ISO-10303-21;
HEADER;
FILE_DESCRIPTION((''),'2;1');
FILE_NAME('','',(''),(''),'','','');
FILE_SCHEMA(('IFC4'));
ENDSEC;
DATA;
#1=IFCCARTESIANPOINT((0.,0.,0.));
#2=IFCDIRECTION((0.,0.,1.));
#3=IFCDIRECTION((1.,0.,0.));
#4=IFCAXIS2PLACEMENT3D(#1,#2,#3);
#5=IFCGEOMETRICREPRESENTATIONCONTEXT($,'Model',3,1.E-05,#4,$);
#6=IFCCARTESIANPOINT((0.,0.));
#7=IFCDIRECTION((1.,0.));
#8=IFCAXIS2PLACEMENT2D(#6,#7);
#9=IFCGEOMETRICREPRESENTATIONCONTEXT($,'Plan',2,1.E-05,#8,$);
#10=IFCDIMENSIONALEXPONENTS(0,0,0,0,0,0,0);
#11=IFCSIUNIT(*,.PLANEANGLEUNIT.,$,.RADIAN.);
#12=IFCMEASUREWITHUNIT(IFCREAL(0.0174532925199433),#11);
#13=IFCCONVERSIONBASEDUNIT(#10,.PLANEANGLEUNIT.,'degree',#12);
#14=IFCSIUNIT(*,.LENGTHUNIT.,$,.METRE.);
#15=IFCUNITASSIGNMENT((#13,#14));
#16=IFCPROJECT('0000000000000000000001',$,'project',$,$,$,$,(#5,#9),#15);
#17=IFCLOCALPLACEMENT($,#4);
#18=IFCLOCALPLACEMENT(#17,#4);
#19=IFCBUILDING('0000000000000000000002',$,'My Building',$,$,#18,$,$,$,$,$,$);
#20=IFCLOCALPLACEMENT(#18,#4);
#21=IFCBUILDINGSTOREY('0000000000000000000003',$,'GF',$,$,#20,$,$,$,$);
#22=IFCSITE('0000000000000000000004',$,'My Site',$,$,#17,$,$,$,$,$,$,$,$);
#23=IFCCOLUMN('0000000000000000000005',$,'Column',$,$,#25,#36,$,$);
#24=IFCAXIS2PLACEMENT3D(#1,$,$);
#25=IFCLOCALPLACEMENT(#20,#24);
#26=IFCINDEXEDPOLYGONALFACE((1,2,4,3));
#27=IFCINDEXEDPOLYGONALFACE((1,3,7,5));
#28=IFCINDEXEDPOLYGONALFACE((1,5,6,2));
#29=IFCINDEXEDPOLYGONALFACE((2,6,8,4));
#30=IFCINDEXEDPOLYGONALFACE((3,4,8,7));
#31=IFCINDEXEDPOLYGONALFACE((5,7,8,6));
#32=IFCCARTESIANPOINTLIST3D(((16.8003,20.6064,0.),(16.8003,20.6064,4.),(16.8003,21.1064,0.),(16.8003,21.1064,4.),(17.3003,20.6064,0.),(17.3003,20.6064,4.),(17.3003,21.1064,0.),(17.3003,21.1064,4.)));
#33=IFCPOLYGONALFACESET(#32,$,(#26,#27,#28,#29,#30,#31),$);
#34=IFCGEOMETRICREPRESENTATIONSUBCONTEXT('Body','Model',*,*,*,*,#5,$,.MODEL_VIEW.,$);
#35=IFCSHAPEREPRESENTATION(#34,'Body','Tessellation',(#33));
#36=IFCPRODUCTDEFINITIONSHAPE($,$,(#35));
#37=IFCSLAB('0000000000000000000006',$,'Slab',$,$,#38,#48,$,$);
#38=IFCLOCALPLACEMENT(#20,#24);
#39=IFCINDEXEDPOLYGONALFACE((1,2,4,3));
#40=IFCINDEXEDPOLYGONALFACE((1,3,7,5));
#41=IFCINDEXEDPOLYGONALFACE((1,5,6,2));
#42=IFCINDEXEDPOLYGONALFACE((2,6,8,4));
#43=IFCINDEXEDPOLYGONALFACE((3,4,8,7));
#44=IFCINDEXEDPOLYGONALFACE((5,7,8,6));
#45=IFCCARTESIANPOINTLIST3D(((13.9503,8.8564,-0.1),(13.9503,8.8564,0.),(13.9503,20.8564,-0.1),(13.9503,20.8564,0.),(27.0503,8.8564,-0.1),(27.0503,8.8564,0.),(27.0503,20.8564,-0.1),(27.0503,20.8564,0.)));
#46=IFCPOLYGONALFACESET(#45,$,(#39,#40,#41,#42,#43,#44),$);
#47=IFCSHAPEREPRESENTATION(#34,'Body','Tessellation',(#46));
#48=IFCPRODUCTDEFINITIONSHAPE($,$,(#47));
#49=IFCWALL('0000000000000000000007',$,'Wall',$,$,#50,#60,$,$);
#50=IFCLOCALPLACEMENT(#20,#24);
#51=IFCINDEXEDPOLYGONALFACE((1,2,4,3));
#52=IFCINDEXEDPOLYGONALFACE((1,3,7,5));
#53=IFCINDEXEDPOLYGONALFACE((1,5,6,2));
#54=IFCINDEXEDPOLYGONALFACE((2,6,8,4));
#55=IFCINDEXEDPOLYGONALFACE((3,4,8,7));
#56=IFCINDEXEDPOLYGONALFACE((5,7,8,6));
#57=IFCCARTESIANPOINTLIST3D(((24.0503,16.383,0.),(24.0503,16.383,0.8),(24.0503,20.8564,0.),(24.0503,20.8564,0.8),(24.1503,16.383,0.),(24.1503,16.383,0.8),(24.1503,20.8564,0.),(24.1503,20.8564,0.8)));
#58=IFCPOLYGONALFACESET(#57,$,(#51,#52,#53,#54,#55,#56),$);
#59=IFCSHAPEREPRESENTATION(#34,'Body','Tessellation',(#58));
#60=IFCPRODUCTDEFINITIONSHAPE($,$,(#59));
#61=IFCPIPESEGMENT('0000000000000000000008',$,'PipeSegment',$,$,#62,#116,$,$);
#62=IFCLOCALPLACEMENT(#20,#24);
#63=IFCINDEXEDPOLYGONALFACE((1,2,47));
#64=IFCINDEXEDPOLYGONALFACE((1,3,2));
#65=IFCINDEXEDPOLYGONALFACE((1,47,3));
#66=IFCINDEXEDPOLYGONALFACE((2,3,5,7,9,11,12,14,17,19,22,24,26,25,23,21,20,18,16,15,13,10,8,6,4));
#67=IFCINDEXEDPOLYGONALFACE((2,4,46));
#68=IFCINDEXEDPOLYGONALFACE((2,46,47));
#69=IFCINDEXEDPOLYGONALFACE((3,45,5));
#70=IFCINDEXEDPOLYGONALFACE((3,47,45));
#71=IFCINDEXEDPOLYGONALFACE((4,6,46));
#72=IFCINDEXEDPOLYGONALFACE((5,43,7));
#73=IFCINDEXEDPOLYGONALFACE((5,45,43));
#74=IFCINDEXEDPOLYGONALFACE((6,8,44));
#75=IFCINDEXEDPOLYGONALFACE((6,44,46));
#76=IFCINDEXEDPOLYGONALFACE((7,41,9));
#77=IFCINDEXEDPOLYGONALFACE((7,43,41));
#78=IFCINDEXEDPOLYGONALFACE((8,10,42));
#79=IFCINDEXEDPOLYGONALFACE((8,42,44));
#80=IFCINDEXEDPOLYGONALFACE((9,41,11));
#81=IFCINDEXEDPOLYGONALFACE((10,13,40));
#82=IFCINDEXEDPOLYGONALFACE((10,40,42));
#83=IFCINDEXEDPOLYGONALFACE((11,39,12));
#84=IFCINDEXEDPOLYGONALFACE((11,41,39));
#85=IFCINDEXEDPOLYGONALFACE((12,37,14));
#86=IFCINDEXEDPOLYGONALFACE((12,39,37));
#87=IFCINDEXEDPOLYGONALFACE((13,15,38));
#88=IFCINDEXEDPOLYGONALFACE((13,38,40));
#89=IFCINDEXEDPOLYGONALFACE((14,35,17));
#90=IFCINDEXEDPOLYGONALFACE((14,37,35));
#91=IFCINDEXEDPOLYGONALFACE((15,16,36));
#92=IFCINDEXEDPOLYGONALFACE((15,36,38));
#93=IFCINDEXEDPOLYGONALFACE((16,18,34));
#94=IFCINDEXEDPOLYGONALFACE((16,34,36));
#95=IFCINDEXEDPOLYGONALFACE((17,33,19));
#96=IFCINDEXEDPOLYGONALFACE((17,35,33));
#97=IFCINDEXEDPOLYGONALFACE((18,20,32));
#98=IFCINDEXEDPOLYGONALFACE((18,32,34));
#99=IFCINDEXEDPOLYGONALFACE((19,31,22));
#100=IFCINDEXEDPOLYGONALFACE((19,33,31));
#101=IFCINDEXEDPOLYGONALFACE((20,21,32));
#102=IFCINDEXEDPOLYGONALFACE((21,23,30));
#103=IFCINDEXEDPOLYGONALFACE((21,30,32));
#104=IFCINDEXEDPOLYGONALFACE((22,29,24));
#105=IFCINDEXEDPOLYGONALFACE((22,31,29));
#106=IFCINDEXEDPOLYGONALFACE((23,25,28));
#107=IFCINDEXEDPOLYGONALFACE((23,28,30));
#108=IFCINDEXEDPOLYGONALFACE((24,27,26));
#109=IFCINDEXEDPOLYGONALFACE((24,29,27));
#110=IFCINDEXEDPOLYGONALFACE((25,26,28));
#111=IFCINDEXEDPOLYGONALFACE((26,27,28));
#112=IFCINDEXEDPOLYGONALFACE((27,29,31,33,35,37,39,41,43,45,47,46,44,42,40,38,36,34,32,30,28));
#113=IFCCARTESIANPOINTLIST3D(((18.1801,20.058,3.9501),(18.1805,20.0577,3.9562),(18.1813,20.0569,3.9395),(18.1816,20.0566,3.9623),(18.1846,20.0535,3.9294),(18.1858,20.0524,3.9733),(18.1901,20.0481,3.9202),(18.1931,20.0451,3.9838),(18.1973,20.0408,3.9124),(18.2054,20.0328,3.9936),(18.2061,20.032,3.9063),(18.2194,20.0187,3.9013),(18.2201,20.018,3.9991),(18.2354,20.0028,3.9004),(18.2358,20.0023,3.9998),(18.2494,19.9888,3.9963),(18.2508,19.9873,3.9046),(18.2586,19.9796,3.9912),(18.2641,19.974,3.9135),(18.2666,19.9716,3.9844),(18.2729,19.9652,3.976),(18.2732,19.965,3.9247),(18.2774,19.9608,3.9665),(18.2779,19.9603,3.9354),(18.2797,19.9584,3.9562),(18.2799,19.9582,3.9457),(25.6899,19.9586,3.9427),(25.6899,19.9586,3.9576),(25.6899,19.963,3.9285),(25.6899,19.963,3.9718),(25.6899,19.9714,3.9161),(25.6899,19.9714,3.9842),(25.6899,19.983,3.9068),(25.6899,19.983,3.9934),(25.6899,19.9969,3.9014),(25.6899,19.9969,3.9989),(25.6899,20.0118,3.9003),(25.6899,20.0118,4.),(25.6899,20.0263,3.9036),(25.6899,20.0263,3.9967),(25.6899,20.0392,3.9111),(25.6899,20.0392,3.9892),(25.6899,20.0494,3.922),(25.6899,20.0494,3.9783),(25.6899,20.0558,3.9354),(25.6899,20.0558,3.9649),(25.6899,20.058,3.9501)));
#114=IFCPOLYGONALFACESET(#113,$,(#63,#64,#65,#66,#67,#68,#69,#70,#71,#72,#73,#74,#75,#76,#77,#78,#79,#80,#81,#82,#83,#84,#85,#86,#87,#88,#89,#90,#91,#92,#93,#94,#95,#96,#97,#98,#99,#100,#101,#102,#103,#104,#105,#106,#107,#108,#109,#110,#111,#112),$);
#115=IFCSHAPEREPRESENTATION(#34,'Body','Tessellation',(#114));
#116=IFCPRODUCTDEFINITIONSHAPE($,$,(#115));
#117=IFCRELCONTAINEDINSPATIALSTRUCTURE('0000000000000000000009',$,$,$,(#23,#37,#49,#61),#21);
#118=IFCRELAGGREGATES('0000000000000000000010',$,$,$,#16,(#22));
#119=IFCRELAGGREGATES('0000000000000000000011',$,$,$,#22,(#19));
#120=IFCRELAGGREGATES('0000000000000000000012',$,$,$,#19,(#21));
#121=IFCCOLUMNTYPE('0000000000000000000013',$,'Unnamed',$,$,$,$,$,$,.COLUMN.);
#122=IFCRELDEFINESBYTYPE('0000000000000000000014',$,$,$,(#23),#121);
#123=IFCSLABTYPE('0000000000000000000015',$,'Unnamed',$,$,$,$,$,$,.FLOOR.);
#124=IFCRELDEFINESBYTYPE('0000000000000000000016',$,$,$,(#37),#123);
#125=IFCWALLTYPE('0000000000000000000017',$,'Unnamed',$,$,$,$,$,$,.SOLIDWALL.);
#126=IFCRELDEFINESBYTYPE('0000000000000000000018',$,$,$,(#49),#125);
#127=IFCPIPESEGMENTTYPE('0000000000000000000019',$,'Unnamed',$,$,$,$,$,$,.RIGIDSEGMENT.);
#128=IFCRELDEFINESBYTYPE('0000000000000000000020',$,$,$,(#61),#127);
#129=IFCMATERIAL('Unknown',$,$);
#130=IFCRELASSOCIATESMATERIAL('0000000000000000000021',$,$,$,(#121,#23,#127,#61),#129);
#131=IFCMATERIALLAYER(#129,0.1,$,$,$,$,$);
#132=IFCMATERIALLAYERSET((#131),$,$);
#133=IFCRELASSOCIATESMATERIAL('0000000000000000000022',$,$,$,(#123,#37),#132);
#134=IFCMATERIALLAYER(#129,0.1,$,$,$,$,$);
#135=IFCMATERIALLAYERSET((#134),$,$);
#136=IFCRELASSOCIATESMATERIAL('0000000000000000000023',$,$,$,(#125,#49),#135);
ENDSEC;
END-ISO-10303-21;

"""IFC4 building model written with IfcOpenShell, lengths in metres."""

from ifc_helpers import new_model, entity, si_unit, converted_unit, frame, origin_with_axes, origin_2d_with_axis, place, context, subcontext, project, spatial, line, indexed_curve, rectangle, circle, outline, extrude, clip, halfspace, material, layer, layer_set, layer_usage, material_profile, profile_set, profile_usage, type_object, element, save


model = new_model("IFC4")

# Units and contexts
model_context = context("Model", 3, precision=1e-05, world=origin_with_axes())
plan_context = context("Plan", 2, precision=1e-05, world=origin_2d_with_axis())
body_context_1 = subcontext(model_context, "Body", "Model", "MODEL_VIEW")
ifc_project = project(units=[converted_unit("PLANEANGLEUNIT", "degree", entity("IfcReal", 0.0174532925199433), si_unit("PLANEANGLEUNIT", "RADIAN"), dimensions=[0, 0, 0, 0, 0, 0, 0]), si_unit("LENGTHUNIT", "METRE")], contexts=[model_context, plan_context])

# Site, building, storey
site_placement = place(None, origin_with_axes())
site = spatial("IfcSite", under=ifc_project, at=site_placement, Name="My Site")
building_placement = place(site_placement, origin_with_axes())
building = spatial("IfcBuilding", under=site, at=building_placement, Name="My Building")
storey_placement = place(building_placement, origin_with_axes())
storey = spatial("IfcBuildingStorey", under=building, at=storey_placement, Name="GF")

# Column
ifc_material = material(Name="Unknown")
ifc_material_profile_1 = material_profile(ifc_material, rectangle(XDim=0.5, YDim=0.5))
ifc_profile_set_1 = profile_set([ifc_material_profile_1])
ifc_profile_usage_1 = profile_usage(ifc_profile_set_1, cardinal=5)
column_type = type_object("IfcColumnType", Name="Unnamed", PredefinedType="COLUMN", material=ifc_profile_set_1)
column_placement = place(storey_placement, frame((17.0503, 20.8564, 0.0), z_axis=(0.0, 0.0, 1.0), x_axis=(1.0, 0.0, 0.0)))
element("IfcColumn", 1, at=column_placement, inside=storey, type_object=column_type, material=ifc_profile_usage_1, Name="Column", context=body_context_1, shape_type="SweptSolid", body=[
    extrude(rectangle(XDim=0.5, YDim=0.5), origin_with_axes(), (0.0, 0.0, 1.0), 4.0),
])

# Slab
ifc_layer_1 = layer(ifc_material, 0.1)
ifc_layer_set_1 = layer_set([ifc_layer_1])
ifc_layer_usage_1 = layer_usage(ifc_layer_set_1, "AXIS3", "POSITIVE", -0.1)
slab_type = type_object("IfcSlabType", Name="Unnamed", PredefinedType="FLOOR", material=ifc_layer_set_1)
slab_placement = place(storey_placement, frame((13.9503, 20.8564, 0.0), z_axis=(0.0, 0.0, 1.0), x_axis=(1.0, 0.0, 0.0)))
element("IfcSlab", 2, at=slab_placement, inside=storey, type_object=slab_type, material=ifc_layer_usage_1, Name="Slab", context=body_context_1, shape_type="SweptSolid", body=[
    extrude(outline(indexed_curve([(0.0, 0.0), (13.1, 0.0), (13.1, -12.0), (0.0, -12.0), (0.0, 0.0)])), frame((0.0, 0.0, -0.1), z_axis=(0.0, 0.0, 1.0), x_axis=(1.0, 0.0, 0.0)), (0.0, 0.0, 1.0), 0.1),
])

# Shared definitions
ifc_layer_2 = layer(ifc_material, 0.1)
ifc_layer_set_2 = layer_set([ifc_layer_2])
wall_type = type_object("IfcWallType", Name="Unnamed", PredefinedType="SOLIDWALL", material=ifc_layer_set_2)

# Wall
ifc_layer_usage_2 = layer_usage(ifc_layer_set_2, "AXIS2", "POSITIVE", 0.0)
wall_1_placement = place(storey_placement, frame((24.1503, 16.383, 0.0), z_axis=(0.0, 0.0, 1.0), x_axis=(0.0, 1.0, 0.0)))
element("IfcWall", 3, at=wall_1_placement, inside=storey, type_object=wall_type, material=ifc_layer_usage_2, Name="Wall", context=body_context_1, shape_type="SweptSolid", body=[
    extrude(outline(indexed_curve([(0.0, 0.0), (0.0, 0.1), (4.4734, 0.1), (4.4734, 0.0)], segments=[line(1, 2, 3, 4, 1)])), origin_with_axes(), (0.0, 0.0, 1.0), 0.8),
])

# Pipe segment
ifc_material_profile_2 = material_profile(ifc_material, circle(Radius=0.05))
ifc_profile_set_2 = profile_set([ifc_material_profile_2])
ifc_profile_usage_2 = profile_usage(ifc_profile_set_2, cardinal=5)
pipe_segment_type = type_object("IfcPipeSegmentType", Name="Unnamed", PredefinedType="RIGIDSEGMENT", material=ifc_profile_set_2)
pipe_segment_placement = place(storey_placement, frame((18.1801, 20.008, 3.9501), z_axis=(1.0, 0.0, 0.0), x_axis=(0.0, 1.0, 0.0)))
element("IfcPipeSegment", 4, at=pipe_segment_placement, inside=storey, type_object=pipe_segment_type, material=ifc_profile_usage_2, Name="PipeSegment", context=body_context_1, shape_type="Clipping", body=[
    clip(extrude(circle(Radius=0.05), origin_with_axes(), (0.0, 0.0, 1.0), 7.5098), halfspace(frame((0.05, -4.0, 0.0), z_axis=(-0.707107, 0.0, -0.707107), x_axis=(0.0, 1.0, 0.0)), False)),
])

save(model, "model.ifc")
